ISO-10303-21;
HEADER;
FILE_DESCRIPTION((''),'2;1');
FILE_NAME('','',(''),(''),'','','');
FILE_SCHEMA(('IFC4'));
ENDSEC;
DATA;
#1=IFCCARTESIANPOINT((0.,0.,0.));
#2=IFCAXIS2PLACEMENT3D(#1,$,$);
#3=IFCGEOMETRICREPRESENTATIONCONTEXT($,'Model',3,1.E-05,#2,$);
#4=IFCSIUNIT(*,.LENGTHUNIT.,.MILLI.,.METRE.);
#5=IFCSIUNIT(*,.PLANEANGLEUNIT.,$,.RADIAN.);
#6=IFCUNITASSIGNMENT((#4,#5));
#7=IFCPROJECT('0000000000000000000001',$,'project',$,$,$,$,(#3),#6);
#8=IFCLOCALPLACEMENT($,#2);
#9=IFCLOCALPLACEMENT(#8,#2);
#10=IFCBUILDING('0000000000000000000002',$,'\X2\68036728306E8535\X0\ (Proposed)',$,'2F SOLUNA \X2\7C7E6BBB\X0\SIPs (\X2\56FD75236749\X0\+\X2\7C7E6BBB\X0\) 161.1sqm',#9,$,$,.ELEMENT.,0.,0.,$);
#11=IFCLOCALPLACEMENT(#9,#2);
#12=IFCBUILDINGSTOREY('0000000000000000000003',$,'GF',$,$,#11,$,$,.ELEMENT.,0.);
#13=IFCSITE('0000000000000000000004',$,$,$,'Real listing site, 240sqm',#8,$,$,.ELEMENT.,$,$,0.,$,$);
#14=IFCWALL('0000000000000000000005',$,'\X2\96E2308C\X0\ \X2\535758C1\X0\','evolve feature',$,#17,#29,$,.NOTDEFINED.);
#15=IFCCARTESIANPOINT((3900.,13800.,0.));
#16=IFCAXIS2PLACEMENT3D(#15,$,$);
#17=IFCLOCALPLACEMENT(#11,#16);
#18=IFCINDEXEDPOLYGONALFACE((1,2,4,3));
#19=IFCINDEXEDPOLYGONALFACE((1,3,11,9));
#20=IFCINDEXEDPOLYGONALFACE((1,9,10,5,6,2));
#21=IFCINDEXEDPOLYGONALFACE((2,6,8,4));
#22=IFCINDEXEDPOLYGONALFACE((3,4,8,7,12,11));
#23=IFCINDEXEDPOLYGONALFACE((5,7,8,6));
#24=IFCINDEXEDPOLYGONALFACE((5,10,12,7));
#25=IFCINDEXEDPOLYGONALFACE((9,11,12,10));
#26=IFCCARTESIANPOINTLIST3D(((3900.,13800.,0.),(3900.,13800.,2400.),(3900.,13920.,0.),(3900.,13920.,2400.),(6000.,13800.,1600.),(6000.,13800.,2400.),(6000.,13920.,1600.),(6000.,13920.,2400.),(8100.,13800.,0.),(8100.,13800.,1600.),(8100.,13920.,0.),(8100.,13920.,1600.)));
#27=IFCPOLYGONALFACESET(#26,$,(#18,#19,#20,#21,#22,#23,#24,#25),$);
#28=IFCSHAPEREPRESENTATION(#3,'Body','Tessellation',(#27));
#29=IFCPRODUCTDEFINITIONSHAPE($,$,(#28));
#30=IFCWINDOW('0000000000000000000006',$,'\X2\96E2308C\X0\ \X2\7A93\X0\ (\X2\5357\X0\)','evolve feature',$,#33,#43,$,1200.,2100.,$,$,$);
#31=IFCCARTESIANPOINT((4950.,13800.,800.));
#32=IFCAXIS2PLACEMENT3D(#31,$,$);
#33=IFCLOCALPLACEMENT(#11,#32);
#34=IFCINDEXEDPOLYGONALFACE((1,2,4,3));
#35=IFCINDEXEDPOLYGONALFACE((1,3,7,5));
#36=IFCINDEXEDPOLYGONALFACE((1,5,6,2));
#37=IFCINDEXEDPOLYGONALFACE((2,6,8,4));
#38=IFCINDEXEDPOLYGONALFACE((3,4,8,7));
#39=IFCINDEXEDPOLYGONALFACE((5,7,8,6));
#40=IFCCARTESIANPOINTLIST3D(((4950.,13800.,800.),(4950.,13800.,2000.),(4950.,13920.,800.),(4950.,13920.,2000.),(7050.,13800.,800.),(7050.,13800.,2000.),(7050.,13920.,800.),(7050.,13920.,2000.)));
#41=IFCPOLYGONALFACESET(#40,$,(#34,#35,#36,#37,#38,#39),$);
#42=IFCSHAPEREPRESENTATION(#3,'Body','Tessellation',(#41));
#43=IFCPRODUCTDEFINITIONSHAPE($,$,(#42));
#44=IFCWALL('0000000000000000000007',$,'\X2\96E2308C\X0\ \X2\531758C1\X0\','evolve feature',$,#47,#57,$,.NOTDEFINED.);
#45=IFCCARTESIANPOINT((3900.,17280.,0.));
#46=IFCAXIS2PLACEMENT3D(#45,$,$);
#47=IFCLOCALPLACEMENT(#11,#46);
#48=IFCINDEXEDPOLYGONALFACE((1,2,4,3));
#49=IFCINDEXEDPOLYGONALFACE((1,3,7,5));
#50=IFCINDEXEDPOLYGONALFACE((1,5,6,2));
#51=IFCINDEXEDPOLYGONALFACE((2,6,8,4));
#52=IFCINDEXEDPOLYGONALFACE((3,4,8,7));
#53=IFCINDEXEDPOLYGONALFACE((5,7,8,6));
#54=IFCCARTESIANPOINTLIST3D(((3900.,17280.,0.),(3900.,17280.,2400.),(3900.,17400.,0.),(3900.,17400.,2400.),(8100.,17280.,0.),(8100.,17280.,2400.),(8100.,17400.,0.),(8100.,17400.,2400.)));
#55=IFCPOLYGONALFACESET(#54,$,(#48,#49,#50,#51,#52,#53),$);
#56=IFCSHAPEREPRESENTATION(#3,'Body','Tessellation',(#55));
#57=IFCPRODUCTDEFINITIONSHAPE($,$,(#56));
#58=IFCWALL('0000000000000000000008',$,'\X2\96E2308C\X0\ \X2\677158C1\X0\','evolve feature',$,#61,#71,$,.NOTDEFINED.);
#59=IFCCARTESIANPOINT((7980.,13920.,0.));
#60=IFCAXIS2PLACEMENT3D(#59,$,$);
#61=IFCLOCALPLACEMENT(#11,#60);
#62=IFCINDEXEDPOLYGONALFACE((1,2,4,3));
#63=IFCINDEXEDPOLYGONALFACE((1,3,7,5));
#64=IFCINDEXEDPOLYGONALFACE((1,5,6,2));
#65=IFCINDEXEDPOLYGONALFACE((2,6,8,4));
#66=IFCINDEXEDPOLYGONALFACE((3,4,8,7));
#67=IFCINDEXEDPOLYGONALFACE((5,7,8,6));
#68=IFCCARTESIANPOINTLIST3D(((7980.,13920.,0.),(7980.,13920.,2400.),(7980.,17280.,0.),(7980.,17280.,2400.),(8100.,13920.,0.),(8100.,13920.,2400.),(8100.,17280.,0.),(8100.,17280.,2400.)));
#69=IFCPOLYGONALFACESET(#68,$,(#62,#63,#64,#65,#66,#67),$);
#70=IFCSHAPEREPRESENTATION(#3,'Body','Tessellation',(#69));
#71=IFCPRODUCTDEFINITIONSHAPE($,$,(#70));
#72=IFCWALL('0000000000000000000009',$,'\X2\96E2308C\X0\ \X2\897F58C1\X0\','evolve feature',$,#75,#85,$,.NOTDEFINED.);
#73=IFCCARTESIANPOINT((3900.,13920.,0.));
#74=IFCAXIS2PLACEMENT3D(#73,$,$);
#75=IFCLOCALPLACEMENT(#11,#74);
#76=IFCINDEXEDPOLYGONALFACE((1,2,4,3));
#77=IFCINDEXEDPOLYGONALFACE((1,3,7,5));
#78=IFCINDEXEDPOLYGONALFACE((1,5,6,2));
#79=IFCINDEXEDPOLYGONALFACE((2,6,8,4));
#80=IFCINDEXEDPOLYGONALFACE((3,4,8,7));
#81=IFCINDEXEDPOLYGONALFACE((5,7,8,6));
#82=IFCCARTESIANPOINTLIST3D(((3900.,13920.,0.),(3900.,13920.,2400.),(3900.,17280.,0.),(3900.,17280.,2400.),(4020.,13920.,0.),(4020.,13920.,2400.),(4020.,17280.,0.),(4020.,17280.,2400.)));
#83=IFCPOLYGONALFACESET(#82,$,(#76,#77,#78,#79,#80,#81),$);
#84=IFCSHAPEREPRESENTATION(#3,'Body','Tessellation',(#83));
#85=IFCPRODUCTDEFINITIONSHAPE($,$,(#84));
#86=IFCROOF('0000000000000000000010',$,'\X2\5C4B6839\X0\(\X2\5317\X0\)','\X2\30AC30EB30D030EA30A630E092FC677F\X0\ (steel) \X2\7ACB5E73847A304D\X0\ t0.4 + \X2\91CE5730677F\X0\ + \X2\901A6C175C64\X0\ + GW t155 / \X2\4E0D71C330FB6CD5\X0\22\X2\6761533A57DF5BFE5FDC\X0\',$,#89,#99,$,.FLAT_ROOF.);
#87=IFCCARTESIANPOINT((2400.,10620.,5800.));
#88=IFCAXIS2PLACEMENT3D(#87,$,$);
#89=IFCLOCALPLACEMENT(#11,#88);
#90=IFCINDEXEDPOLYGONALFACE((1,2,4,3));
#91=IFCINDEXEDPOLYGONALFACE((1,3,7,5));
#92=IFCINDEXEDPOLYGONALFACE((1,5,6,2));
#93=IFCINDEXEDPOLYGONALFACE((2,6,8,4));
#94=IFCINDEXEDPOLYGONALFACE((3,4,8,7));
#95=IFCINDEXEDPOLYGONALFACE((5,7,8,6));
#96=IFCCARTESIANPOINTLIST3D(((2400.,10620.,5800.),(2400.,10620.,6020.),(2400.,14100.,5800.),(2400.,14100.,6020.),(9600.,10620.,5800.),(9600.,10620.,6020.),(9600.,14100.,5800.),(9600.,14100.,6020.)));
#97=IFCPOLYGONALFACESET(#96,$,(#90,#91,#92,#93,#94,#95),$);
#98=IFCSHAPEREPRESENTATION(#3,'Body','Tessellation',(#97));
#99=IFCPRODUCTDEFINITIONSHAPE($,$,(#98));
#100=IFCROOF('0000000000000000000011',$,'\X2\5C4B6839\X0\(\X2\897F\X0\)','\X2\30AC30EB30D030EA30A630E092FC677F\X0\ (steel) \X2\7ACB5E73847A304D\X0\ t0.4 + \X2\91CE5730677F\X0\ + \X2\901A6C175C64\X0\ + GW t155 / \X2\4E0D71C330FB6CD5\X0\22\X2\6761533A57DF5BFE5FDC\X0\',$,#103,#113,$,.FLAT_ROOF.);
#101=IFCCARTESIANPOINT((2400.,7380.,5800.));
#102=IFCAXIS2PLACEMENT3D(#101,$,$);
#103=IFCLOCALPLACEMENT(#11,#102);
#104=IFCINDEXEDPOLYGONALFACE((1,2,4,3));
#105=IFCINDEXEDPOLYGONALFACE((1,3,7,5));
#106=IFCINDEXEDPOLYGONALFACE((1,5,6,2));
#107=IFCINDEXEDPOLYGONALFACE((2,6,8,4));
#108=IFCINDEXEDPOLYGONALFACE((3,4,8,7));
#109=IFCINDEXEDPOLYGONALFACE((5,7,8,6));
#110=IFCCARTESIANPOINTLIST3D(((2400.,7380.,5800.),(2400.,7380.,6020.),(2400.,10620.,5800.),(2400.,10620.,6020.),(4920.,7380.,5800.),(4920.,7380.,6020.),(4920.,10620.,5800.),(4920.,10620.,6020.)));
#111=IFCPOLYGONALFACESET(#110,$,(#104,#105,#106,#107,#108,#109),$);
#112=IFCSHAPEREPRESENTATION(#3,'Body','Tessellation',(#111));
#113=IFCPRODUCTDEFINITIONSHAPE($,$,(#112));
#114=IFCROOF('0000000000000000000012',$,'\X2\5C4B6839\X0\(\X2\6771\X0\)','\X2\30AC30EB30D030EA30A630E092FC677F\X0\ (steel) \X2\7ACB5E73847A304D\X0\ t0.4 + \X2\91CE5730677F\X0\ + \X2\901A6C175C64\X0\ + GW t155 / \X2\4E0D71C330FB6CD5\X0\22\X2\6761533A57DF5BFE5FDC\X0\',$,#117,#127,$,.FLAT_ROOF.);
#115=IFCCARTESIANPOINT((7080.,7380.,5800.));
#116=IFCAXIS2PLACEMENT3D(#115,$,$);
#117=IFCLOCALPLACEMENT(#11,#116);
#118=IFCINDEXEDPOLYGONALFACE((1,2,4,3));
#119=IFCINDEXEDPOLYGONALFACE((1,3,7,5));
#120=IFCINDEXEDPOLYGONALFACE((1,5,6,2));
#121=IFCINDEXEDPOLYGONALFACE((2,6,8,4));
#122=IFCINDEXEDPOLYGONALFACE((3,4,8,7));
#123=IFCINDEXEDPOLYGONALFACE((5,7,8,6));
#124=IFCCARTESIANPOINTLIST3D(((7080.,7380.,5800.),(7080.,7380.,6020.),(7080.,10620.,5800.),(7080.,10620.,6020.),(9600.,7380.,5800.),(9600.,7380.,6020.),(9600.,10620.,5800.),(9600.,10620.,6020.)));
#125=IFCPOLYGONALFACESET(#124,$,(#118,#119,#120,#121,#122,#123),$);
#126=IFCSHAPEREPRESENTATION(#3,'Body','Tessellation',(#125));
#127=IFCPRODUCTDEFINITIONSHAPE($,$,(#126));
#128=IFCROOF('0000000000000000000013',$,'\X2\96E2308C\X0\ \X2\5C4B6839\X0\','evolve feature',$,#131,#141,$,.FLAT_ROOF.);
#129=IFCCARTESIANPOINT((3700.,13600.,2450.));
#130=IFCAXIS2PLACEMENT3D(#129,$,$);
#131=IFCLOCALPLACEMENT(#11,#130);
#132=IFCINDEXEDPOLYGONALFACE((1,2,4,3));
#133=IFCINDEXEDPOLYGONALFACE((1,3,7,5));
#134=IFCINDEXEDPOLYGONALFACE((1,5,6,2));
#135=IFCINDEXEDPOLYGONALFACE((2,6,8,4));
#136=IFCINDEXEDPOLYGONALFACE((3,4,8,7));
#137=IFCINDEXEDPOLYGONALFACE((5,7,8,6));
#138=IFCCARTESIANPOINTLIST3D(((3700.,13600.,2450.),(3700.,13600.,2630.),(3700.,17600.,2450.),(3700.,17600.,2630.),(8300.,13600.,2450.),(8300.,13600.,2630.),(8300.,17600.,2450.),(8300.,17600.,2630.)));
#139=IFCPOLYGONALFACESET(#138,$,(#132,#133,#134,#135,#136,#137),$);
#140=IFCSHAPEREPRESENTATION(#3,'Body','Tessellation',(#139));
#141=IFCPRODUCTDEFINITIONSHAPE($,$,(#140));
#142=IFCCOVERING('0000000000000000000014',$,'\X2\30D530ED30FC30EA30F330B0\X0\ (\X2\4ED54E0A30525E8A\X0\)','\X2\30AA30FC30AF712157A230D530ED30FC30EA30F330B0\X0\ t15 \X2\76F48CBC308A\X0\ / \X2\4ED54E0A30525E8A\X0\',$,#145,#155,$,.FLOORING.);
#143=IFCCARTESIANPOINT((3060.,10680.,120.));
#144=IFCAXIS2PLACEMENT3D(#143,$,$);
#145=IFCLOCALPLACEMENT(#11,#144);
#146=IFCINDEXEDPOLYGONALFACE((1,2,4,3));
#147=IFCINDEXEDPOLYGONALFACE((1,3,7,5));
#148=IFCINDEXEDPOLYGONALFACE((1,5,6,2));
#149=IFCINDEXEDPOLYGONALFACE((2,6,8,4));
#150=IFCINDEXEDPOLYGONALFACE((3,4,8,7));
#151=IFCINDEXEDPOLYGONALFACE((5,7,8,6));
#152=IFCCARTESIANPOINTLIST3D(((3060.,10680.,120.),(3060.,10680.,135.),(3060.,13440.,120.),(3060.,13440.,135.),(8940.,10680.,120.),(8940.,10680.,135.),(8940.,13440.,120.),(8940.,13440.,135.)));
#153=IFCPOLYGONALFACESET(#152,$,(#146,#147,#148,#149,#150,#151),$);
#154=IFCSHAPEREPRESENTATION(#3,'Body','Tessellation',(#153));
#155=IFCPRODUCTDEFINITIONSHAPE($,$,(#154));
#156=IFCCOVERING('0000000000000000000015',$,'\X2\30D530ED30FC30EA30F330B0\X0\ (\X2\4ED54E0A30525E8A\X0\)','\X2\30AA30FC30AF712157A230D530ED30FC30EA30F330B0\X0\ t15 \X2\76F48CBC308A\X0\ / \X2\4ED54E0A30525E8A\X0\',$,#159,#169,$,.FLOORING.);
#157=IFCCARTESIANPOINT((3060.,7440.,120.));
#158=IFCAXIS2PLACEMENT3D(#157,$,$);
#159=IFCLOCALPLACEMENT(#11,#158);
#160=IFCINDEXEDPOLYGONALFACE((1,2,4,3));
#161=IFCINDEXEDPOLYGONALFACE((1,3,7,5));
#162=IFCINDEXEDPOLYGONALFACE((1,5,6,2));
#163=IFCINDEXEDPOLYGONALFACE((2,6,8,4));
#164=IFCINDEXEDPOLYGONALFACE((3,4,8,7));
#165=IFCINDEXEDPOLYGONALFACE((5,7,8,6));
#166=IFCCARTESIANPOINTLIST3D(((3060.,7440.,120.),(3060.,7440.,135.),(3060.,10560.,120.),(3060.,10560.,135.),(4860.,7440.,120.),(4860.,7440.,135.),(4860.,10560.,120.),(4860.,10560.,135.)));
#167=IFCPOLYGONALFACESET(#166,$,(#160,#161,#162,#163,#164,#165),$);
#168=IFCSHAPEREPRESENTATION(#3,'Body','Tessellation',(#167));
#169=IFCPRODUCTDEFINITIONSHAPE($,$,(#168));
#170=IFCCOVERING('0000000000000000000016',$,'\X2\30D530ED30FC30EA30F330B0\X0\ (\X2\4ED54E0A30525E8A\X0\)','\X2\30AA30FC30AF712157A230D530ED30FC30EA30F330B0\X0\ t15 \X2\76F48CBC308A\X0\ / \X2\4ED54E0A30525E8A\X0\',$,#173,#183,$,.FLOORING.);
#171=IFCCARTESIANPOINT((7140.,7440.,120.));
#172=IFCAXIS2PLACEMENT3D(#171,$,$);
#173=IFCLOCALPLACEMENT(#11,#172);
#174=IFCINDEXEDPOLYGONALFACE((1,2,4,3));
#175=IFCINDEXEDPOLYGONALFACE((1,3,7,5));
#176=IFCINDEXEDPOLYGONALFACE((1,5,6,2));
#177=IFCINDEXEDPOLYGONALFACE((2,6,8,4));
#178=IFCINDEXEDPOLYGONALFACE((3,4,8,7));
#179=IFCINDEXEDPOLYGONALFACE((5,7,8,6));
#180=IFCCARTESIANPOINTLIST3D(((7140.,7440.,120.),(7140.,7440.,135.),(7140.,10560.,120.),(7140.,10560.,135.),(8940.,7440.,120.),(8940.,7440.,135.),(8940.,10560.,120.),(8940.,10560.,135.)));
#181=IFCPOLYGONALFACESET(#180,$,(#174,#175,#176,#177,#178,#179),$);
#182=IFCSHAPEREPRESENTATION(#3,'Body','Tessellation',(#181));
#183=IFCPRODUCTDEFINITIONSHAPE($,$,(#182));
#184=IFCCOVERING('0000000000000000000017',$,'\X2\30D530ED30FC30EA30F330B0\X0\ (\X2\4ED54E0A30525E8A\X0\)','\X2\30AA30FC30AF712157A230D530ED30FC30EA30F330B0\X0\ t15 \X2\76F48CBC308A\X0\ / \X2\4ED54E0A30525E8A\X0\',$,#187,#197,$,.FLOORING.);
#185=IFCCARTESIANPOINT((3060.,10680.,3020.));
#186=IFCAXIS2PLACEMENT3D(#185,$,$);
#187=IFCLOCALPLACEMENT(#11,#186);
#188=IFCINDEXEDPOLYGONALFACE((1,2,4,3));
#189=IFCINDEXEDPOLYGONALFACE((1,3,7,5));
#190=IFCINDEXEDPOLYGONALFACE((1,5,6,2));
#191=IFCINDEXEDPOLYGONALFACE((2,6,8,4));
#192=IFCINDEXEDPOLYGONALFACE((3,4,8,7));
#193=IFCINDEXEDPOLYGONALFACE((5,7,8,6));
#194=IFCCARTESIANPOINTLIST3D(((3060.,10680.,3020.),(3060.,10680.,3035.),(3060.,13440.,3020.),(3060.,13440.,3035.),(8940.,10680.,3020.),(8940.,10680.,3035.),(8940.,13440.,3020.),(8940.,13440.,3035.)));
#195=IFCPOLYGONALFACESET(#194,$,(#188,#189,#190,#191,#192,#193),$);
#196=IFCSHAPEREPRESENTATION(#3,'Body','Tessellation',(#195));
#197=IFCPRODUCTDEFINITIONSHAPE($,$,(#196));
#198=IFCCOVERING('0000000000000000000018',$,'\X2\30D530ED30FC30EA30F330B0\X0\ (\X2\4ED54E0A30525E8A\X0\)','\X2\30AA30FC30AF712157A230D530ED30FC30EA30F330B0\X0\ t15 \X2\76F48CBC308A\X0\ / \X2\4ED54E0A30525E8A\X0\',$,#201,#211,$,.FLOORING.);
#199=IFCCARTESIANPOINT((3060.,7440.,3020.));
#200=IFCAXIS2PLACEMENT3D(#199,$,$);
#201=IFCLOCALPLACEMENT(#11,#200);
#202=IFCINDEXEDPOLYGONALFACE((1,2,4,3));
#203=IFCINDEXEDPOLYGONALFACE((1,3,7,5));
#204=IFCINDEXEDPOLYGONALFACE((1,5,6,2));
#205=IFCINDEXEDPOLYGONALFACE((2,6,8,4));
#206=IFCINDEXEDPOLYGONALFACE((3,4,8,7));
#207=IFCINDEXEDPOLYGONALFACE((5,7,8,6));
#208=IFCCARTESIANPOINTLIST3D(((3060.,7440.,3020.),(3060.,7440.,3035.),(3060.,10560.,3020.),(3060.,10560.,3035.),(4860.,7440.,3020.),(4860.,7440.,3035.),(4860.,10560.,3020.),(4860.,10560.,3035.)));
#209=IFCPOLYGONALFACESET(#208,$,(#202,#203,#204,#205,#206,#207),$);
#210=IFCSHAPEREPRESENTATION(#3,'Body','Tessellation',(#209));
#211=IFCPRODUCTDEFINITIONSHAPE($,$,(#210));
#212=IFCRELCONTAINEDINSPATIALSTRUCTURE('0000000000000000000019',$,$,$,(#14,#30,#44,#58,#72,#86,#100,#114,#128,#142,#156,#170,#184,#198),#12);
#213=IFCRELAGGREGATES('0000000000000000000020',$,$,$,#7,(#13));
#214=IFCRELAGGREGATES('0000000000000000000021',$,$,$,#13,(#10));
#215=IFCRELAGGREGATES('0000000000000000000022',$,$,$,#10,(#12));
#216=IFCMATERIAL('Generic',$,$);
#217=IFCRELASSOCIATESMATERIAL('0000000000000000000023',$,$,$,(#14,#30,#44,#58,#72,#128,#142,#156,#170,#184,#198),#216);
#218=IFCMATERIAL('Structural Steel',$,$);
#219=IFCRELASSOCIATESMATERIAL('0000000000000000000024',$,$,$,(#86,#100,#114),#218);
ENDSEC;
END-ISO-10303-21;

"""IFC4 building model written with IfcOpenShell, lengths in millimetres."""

from ifc_helpers import new_model, si_unit, frame, frame_2d, origin, place, context, project, spatial, rectangle, extrude, material, element, fill, save


model = new_model("IFC4")

# Units and contexts
model_context = context("Model", 3, precision=1e-05, world=origin())
ifc_project = project(units=[si_unit("LENGTHUNIT", "METRE", prefix="MILLI"), si_unit("PLANEANGLEUNIT", "RADIAN")], contexts=[model_context])

# Site, building, storey
site_placement = place(None, origin())
site = spatial("IfcSite", under=ifc_project, at=site_placement, ObjectType="Real listing site, 240sqm", CompositionType="ELEMENT", RefElevation=0.0)
building_placement = place(site_placement, origin())
building = spatial("IfcBuilding", under=site, at=building_placement, Name="栃木の蔵 (Proposed)", ObjectType="2F SOLUNA 籾殻SIPs (国産杉+籾殻) 161.1sqm", CompositionType="ELEMENT", ElevationOfRefHeight=0.0, ElevationOfTerrain=0.0)
storey_placement = place(building_placement, origin())
storey = spatial("IfcBuildingStorey", under=building, at=storey_placement, Name="GF", CompositionType="ELEMENT", Elevation=0.0)

# Shared definitions
ifc_material_1 = material(Name="Generic")

# Wall, opening, window
wall_1_placement = place(storey_placement, frame((3900.0, 13800.0, 0.0)))
wall_1 = element("IfcWall", 1, at=wall_1_placement, inside=storey, material=ifc_material_1, Name="離れ 南壁", Description="evolve feature", PredefinedType="NOTDEFINED", context=model_context, shape_type="SweptSolid", body=[
    extrude(rectangle(XDim=4200.0, YDim=120.0, at=frame_2d((2100.0, 60.0))), frame((3900.0, 13800.0, 0.0)), (0.0, 0.0, 1.0), 2400.0),
])
opening_1_placement = place(storey_placement, frame((4950.0, 13800.0, 800.0)))
opening_1 = element("IfcOpeningElement", 2, at=opening_1_placement, cuts=wall_1, PredefinedType="NOTDEFINED", context=model_context, shape_type="SweptSolid", body=[
    extrude(rectangle(XDim=2100.0, YDim=120.0, at=frame_2d((1050.0, 60.0))), frame((4950.0, 13800.0, 800.0)), (0.0, 0.0, 1.0), 1200.0),
])
window_1_placement = place(storey_placement, frame((4950.0, 13800.0, 800.0)))
window_1 = element("IfcWindow", 3, at=window_1_placement, inside=storey, material=ifc_material_1, Name="離れ 窓 (南)", Description="evolve feature", OverallHeight=1200.0, OverallWidth=2100.0, context=model_context, shape_type="SweptSolid", body=[
    extrude(rectangle(XDim=2100.0, YDim=120.0, at=frame_2d((1050.0, 60.0))), frame((4950.0, 13800.0, 800.0)), (0.0, 0.0, 1.0), 1200.0),
])
fill(opening_1, window_1)

# Walls
wall_2_placement = place(storey_placement, frame((3900.0, 17280.0, 0.0)))
element("IfcWall", 4, at=wall_2_placement, inside=storey, material=ifc_material_1, Name="離れ 北壁", Description="evolve feature", PredefinedType="NOTDEFINED", context=model_context, shape_type="SweptSolid", body=[
    extrude(rectangle(XDim=4200.0, YDim=120.0, at=frame_2d((2100.0, 60.0))), frame((3900.0, 17280.0, 0.0)), (0.0, 0.0, 1.0), 2400.0),
])
wall_3_placement = place(storey_placement, frame((7980.0, 13920.0, 0.0)))
element("IfcWall", 5, at=wall_3_placement, inside=storey, material=ifc_material_1, Name="離れ 東壁", Description="evolve feature", PredefinedType="NOTDEFINED", context=model_context, shape_type="SweptSolid", body=[
    extrude(rectangle(XDim=120.0, YDim=3360.0, at=frame_2d((60.0, 1680.0))), frame((7980.0, 13920.0, 0.0)), (0.0, 0.0, 1.0), 2400.0),
])
wall_4_placement = place(storey_placement, frame((3900.0, 13920.0, 0.0)))
element("IfcWall", 6, at=wall_4_placement, inside=storey, material=ifc_material_1, Name="離れ 西壁", Description="evolve feature", PredefinedType="NOTDEFINED", context=model_context, shape_type="SweptSolid", body=[
    extrude(rectangle(XDim=120.0, YDim=3360.0, at=frame_2d((60.0, 1680.0))), frame((3900.0, 13920.0, 0.0)), (0.0, 0.0, 1.0), 2400.0),
])

# Roofs
ifc_material_2 = material(Name="Structural Steel")
for number, where, name in (
    (7, (2400.0, 10620.0, 5800.0), "屋根(北)"),
):
    element("IfcRoof", number, at=place(storey_placement, frame(where)), inside=storey, material=ifc_material_2, Name=name, Description="ガルバリウム鋼板 (steel) 立平葺き t0.4 + 野地板 + 通気層 + GW t155 / 不燃・法22条区域対応", PredefinedType="FLAT_ROOF", context=model_context, shape_type="SweptSolid", body=[
        extrude(rectangle(XDim=7200.0, YDim=3480.0, at=frame_2d((3600.0, 1740.0))), frame((2400.0, 10620.0, 5800.0)), (0.0, 0.0, 1.0), 220.0),
    ])
roof_1_placement = place(storey_placement, frame((2400.0, 7380.0, 5800.0)))
element("IfcRoof", 8, at=roof_1_placement, inside=storey, material=ifc_material_2, Name="屋根(西)", Description="ガルバリウム鋼板 (steel) 立平葺き t0.4 + 野地板 + 通気層 + GW t155 / 不燃・法22条区域対応", PredefinedType="FLAT_ROOF", context=model_context, shape_type="SweptSolid", body=[
    extrude(rectangle(XDim=2520.0, YDim=3240.0, at=frame_2d((1260.0, 1620.0))), frame((2400.0, 7380.0, 5800.0)), (0.0, 0.0, 1.0), 220.0),
])
roof_2_placement = place(storey_placement, frame((7080.0, 7380.0, 5800.0)))
element("IfcRoof", 9, at=roof_2_placement, inside=storey, material=ifc_material_2, Name="屋根(東)", Description="ガルバリウム鋼板 (steel) 立平葺き t0.4 + 野地板 + 通気層 + GW t155 / 不燃・法22条区域対応", PredefinedType="FLAT_ROOF", context=model_context, shape_type="SweptSolid", body=[
    extrude(rectangle(XDim=2520.0, YDim=3240.0, at=frame_2d((1260.0, 1620.0))), frame((7080.0, 7380.0, 5800.0)), (0.0, 0.0, 1.0), 220.0),
])
roof_3_placement = place(storey_placement, frame((3700.0, 13600.0, 2450.0)))
element("IfcRoof", 10, at=roof_3_placement, inside=storey, material=ifc_material_1, Name="離れ 屋根", Description="evolve feature", PredefinedType="FLAT_ROOF", context=model_context, shape_type="SweptSolid", body=[
    extrude(rectangle(XDim=4600.0, YDim=4000.0, at=frame_2d((2300.0, 2000.0))), frame((3700.0, 13600.0, 2450.0)), (0.0, 0.0, 1.0), 180.0),
])

# Coverings
covering_1_placement = place(storey_placement, frame((3060.0, 10680.0, 120.0)))
element("IfcCovering", 11, at=covering_1_placement, inside=storey, material=ifc_material_1, Name="フローリング (仕上げ床)", Description="オーク無垢フローリング t15 直貼り / 仕上げ床", PredefinedType="FLOORING", context=model_context, shape_type="SweptSolid", body=[
    extrude(rectangle(XDim=5880.0, YDim=2760.0, at=frame_2d((2940.0, 1380.0))), frame((3060.0, 10680.0, 120.0)), (0.0, 0.0, 1.0), 15.0),
])
covering_2_placement = place(storey_placement, frame((3060.0, 7440.0, 120.0)))
element("IfcCovering", 12, at=covering_2_placement, inside=storey, material=ifc_material_1, Name="フローリング (仕上げ床)", Description="オーク無垢フローリング t15 直貼り / 仕上げ床", PredefinedType="FLOORING", context=model_context, shape_type="SweptSolid", body=[
    extrude(rectangle(XDim=1800.0, YDim=3120.0, at=frame_2d((900.0, 1560.0))), frame((3060.0, 7440.0, 120.0)), (0.0, 0.0, 1.0), 15.0),
])
covering_3_placement = place(storey_placement, frame((7140.0, 7440.0, 120.0)))
element("IfcCovering", 13, at=covering_3_placement, inside=storey, material=ifc_material_1, Name="フローリング (仕上げ床)", Description="オーク無垢フローリング t15 直貼り / 仕上げ床", PredefinedType="FLOORING", context=model_context, shape_type="SweptSolid", body=[
    extrude(rectangle(XDim=1800.0, YDim=3120.0, at=frame_2d((900.0, 1560.0))), frame((7140.0, 7440.0, 120.0)), (0.0, 0.0, 1.0), 15.0),
])
covering_4_placement = place(storey_placement, frame((3060.0, 10680.0, 3020.0)))
element("IfcCovering", 14, at=covering_4_placement, inside=storey, material=ifc_material_1, Name="フローリング (仕上げ床)", Description="オーク無垢フローリング t15 直貼り / 仕上げ床", PredefinedType="FLOORING", context=model_context, shape_type="SweptSolid", body=[
    extrude(rectangle(XDim=5880.0, YDim=2760.0, at=frame_2d((2940.0, 1380.0))), frame((3060.0, 10680.0, 3020.0)), (0.0, 0.0, 1.0), 15.0),
])
covering_5_placement = place(storey_placement, frame((3060.0, 7440.0, 3020.0)))
element("IfcCovering", 15, at=covering_5_placement, inside=storey, material=ifc_material_1, Name="フローリング (仕上げ床)", Description="オーク無垢フローリング t15 直貼り / 仕上げ床", PredefinedType="FLOORING", context=model_context, shape_type="SweptSolid", body=[
    extrude(rectangle(XDim=1800.0, YDim=3120.0, at=frame_2d((900.0, 1560.0))), frame((3060.0, 7440.0, 3020.0)), (0.0, 0.0, 1.0), 15.0),
])

save(model, "model.ifc")
